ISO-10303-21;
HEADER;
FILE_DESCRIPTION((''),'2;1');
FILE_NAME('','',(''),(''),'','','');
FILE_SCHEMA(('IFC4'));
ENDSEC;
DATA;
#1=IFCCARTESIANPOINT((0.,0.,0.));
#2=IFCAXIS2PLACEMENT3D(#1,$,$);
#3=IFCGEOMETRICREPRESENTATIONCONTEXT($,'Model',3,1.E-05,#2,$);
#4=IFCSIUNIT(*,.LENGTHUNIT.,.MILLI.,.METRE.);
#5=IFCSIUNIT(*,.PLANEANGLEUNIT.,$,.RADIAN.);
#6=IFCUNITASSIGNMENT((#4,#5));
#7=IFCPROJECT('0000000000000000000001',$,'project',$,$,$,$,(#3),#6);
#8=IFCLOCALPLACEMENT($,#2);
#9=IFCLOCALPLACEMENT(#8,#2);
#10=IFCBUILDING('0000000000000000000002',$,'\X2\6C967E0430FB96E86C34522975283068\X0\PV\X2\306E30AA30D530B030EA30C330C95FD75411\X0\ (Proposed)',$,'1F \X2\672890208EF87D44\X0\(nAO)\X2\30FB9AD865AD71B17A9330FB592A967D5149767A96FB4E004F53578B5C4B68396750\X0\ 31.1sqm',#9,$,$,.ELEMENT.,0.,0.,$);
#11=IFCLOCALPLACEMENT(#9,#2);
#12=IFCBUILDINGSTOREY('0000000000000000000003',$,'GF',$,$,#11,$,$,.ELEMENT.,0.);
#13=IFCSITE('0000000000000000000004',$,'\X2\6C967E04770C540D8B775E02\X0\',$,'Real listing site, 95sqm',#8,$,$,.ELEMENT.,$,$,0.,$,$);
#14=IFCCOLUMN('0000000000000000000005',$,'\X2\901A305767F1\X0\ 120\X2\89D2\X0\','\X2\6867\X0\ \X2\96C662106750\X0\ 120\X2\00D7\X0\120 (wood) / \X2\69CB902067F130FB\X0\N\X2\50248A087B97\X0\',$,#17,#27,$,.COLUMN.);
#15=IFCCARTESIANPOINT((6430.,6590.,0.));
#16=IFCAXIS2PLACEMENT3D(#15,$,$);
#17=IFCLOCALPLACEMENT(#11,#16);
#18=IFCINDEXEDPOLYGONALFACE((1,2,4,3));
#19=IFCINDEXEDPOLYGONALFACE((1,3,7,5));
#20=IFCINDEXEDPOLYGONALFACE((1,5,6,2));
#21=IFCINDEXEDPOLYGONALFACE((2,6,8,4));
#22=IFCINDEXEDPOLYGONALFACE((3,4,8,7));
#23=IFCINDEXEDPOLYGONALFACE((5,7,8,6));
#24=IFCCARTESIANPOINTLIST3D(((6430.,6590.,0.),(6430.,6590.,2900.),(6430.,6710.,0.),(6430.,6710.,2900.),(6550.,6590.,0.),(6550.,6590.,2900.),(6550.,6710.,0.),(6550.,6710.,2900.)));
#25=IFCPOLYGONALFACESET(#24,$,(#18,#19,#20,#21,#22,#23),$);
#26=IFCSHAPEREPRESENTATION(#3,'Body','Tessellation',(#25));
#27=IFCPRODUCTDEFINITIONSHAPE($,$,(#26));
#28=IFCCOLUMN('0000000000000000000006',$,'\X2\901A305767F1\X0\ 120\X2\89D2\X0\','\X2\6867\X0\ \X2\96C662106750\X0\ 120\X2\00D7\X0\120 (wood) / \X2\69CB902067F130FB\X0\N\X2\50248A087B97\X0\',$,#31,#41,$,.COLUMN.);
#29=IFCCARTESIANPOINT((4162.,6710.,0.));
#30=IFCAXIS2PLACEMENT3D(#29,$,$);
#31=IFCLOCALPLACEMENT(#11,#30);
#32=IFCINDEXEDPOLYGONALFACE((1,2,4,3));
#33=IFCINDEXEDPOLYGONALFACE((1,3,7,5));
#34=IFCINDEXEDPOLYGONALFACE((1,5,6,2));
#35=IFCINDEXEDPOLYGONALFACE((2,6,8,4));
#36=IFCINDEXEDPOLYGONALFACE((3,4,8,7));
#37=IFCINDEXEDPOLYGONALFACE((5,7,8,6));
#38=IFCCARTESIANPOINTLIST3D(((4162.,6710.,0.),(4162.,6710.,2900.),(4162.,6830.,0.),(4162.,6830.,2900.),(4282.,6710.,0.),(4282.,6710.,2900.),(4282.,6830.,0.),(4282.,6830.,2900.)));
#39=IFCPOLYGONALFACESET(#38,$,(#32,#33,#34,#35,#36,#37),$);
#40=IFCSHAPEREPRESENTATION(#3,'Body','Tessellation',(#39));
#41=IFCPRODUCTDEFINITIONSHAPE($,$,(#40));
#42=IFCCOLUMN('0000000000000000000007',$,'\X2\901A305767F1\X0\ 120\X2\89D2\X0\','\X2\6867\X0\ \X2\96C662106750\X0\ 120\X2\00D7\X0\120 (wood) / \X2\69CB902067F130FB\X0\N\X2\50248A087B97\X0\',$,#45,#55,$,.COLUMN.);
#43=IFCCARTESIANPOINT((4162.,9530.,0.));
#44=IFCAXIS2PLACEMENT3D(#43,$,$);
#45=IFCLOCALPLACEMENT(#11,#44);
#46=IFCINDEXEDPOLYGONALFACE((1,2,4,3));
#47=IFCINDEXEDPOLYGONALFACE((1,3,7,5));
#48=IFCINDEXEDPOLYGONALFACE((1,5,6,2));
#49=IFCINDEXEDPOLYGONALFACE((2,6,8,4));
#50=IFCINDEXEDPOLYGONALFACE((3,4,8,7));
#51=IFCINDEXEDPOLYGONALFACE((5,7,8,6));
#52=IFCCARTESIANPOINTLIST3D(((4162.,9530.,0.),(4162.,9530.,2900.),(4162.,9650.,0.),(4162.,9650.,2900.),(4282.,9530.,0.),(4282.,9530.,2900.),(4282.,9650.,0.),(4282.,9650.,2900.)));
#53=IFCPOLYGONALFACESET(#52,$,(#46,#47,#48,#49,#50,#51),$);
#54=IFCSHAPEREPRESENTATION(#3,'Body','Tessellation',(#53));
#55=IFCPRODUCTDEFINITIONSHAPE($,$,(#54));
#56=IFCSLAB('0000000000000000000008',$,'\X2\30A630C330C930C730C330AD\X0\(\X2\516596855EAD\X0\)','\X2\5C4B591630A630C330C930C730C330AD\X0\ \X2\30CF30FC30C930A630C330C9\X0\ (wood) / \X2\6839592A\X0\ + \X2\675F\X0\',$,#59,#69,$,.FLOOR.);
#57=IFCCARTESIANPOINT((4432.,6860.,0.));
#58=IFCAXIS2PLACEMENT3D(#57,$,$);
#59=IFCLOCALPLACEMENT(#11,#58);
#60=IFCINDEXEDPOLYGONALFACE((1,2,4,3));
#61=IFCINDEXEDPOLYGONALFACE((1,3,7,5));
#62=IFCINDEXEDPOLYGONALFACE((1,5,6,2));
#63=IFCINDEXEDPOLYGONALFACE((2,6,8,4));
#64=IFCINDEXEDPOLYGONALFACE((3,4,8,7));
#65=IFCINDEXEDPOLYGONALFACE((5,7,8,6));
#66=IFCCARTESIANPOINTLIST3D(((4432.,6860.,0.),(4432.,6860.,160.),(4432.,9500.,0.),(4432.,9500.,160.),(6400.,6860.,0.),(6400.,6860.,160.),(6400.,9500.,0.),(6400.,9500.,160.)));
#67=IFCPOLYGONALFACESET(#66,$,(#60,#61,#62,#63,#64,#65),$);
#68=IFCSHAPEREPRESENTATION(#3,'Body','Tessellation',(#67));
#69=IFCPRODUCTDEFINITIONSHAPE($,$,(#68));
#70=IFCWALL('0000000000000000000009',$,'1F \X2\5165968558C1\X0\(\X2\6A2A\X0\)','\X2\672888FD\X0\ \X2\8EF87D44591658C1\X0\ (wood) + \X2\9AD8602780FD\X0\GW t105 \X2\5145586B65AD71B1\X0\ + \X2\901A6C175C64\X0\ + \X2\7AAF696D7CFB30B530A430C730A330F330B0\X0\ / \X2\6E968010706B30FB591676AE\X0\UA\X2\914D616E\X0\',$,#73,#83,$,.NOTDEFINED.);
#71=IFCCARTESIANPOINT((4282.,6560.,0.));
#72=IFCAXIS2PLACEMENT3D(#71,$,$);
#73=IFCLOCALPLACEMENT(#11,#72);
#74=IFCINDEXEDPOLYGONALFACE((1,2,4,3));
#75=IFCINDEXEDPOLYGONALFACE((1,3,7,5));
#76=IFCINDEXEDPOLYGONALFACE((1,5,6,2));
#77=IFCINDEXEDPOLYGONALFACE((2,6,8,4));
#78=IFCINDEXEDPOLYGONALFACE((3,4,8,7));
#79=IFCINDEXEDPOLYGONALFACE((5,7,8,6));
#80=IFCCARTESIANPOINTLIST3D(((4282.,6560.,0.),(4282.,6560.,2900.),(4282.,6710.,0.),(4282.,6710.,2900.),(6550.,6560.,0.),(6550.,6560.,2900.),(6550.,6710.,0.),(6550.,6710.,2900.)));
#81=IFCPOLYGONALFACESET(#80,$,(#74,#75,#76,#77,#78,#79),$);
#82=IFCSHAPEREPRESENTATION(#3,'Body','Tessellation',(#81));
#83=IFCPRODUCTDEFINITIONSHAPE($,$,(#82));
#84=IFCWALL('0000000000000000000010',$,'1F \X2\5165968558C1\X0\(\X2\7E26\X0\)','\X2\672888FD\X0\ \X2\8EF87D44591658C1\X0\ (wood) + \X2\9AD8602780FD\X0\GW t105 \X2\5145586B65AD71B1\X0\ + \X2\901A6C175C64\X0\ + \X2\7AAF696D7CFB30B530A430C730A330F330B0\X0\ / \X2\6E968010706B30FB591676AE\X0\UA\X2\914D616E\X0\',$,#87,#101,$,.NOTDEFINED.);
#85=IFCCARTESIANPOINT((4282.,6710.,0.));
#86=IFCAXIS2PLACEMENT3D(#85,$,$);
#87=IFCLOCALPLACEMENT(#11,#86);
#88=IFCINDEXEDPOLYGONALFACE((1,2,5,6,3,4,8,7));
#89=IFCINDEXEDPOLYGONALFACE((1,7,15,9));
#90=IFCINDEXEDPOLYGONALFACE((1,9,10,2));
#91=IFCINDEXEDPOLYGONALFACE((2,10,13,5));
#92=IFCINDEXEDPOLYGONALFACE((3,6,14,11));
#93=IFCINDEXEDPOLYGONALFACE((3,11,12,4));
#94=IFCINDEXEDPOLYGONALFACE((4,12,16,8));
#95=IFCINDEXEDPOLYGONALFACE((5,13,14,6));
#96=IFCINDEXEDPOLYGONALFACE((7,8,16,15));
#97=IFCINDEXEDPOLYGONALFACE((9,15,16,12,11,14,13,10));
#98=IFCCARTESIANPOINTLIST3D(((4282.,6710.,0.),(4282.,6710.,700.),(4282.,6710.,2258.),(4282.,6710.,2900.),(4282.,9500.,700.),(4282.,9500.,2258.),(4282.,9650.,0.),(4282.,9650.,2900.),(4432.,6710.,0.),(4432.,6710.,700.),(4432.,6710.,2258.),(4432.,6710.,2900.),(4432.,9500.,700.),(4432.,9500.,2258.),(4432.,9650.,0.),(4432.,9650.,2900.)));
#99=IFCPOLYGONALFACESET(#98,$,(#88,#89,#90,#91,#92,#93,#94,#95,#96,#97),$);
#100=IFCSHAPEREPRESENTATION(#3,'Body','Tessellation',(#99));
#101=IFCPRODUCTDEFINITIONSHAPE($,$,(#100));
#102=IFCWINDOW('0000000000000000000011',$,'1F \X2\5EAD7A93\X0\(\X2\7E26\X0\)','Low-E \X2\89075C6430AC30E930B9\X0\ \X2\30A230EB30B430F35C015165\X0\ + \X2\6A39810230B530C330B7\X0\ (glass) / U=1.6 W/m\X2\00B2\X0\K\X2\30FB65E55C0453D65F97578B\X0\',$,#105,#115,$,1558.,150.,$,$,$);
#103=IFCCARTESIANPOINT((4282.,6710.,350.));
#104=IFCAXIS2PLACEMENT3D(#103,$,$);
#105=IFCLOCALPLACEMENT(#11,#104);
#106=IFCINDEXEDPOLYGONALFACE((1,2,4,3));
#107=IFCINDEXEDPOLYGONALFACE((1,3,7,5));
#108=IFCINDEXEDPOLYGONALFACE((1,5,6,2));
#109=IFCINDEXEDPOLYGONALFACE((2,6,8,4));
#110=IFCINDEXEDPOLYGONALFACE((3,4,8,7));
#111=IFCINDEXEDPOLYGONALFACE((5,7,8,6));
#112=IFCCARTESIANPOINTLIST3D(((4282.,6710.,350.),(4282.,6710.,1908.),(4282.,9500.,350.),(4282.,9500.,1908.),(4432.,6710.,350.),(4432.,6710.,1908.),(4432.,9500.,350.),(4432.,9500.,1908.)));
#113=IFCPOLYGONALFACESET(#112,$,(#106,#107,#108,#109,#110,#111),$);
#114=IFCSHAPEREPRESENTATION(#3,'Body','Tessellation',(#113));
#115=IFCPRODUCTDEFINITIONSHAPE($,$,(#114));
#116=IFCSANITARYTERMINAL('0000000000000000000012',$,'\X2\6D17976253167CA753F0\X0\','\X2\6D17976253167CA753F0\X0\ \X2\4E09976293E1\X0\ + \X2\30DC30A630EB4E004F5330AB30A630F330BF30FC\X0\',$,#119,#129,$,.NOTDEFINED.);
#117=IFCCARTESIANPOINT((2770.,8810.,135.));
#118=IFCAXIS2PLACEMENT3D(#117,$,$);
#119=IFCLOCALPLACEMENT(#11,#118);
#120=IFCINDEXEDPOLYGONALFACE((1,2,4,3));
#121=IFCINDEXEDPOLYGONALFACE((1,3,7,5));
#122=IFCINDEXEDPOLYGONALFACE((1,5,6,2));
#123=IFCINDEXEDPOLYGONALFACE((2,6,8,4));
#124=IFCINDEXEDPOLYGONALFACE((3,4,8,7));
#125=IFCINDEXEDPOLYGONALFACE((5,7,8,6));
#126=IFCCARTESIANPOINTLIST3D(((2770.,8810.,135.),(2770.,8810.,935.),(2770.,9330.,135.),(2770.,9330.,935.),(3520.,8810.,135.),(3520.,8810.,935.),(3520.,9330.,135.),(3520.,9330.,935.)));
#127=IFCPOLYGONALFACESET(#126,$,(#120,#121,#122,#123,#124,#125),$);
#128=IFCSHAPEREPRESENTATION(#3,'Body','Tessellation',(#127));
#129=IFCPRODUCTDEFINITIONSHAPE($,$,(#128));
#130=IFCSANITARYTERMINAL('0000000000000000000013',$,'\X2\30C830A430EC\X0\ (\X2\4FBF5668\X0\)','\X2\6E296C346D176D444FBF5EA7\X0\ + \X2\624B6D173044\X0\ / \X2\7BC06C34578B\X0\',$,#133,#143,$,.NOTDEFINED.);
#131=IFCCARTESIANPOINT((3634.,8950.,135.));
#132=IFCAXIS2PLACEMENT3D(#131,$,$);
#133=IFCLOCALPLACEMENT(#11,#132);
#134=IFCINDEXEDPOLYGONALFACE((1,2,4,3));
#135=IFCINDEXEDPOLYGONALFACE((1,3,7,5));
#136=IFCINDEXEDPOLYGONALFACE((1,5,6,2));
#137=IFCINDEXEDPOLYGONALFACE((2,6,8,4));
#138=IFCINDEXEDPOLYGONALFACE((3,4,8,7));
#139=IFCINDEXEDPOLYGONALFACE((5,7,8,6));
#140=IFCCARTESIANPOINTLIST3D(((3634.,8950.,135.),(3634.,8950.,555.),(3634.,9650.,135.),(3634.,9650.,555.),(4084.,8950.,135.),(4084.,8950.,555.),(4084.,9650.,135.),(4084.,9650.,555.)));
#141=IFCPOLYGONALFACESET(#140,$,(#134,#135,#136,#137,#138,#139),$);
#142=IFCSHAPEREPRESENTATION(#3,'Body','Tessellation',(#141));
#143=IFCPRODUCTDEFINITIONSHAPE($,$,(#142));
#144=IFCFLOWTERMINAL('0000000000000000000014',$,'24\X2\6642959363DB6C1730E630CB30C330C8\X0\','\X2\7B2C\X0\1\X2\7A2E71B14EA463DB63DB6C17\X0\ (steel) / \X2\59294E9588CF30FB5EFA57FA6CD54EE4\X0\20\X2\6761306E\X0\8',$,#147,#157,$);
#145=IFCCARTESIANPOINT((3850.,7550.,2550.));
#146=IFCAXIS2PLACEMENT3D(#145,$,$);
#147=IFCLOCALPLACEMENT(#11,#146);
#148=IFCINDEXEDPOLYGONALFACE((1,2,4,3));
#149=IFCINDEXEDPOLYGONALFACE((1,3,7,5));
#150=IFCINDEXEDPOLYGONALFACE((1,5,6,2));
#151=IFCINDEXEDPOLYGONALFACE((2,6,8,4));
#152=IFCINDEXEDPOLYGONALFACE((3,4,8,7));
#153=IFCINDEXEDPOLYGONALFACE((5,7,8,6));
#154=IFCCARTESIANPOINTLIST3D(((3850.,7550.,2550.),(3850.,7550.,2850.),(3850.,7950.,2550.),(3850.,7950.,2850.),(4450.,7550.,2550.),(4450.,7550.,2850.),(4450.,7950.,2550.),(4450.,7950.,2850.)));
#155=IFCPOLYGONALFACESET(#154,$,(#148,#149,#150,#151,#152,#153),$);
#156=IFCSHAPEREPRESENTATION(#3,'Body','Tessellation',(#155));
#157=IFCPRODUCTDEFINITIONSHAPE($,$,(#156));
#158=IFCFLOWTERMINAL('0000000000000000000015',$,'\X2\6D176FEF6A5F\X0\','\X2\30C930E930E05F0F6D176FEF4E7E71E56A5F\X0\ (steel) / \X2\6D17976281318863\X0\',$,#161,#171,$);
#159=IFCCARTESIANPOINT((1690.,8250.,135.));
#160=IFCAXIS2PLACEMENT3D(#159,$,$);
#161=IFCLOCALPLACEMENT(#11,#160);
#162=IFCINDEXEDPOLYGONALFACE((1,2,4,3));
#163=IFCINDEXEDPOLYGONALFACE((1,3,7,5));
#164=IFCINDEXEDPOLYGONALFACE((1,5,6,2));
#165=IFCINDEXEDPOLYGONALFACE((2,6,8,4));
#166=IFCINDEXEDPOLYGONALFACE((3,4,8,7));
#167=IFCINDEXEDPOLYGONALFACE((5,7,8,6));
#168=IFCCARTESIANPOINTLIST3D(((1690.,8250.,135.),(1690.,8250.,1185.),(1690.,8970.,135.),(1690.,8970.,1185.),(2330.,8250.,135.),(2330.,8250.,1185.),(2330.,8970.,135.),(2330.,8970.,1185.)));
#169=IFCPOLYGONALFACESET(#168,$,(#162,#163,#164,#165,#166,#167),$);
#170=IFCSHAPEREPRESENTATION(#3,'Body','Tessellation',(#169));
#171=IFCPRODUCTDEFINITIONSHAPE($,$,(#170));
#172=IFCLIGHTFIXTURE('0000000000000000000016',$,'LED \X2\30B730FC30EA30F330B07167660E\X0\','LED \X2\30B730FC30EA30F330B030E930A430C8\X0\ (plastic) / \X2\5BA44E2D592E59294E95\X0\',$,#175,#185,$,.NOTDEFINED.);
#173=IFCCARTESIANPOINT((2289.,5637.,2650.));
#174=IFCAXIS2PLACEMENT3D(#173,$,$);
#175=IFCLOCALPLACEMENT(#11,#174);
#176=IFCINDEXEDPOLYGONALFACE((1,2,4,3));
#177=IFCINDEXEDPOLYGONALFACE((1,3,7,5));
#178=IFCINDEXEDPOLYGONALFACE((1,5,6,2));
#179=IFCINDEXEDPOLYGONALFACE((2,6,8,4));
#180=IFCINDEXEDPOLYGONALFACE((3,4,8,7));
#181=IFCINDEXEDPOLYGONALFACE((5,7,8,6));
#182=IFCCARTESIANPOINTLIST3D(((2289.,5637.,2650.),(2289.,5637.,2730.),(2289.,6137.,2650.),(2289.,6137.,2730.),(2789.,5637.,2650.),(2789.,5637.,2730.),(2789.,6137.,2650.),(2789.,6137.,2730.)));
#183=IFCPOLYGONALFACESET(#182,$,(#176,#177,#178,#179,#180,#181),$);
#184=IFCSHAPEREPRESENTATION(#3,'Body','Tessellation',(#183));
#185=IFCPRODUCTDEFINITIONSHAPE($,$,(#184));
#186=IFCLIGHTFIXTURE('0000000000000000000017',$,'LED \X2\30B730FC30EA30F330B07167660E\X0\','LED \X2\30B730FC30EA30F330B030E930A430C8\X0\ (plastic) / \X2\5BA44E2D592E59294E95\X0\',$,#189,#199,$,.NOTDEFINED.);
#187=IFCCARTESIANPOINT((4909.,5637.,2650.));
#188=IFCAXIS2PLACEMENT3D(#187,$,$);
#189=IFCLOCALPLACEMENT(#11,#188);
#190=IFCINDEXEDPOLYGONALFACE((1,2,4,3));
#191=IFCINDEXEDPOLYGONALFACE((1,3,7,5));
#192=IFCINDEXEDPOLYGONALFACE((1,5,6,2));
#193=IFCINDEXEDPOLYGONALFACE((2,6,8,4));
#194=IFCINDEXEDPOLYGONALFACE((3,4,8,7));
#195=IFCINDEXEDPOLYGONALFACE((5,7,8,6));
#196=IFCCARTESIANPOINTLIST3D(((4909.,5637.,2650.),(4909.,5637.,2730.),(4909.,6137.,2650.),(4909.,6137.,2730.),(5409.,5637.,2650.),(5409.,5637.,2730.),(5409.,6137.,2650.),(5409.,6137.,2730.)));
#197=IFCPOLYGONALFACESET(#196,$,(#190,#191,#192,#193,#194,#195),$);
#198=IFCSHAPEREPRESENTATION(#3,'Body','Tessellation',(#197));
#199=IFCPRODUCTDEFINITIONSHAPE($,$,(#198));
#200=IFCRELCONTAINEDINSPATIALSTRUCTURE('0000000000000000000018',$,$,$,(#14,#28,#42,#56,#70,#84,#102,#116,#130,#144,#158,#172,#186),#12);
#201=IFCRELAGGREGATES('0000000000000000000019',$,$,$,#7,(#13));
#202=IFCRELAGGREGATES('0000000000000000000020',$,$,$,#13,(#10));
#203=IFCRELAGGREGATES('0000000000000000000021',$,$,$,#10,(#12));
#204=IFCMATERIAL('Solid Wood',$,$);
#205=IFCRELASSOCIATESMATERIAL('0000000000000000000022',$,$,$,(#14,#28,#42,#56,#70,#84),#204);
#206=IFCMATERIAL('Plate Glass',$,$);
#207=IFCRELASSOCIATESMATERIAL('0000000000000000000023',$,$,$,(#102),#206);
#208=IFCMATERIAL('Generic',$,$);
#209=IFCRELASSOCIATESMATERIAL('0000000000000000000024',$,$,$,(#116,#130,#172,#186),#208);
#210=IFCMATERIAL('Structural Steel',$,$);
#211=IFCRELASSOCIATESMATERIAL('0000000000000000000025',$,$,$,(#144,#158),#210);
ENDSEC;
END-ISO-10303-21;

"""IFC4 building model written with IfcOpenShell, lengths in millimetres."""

from ifc_helpers import new_model, si_unit, frame, frame_2d, origin, place, context, project, spatial, rectangle, extrude, material, element, fill, save


model = new_model("IFC4")

# Units and contexts
model_context = context("Model", 3, precision=1e-05, world=origin())
ifc_project = project(units=[si_unit("LENGTHUNIT", "METRE", prefix="MILLI"), si_unit("PLANEANGLEUNIT", "RADIAN")], contexts=[model_context])

# Site, building, storey
site_placement = place(None, origin())
site = spatial("IfcSite", under=ifc_project, at=site_placement, Name="沖縄県名護市", ObjectType="Real listing site, 95sqm", CompositionType="ELEMENT", RefElevation=0.0)
building_placement = place(site_placement, origin())
building = spatial("IfcBuilding", under=site, at=building_placement, Name="沖縄・雨水利用とPVのオフグリッド志向 (Proposed)", ObjectType="1F 木造軸組(nAO)・高断熱窓・太陽光発電一体型屋根材 31.1sqm", CompositionType="ELEMENT", ElevationOfRefHeight=0.0, ElevationOfTerrain=0.0)
storey_placement = place(building_placement, origin())
storey = spatial("IfcBuildingStorey", under=building, at=storey_placement, Name="GF", CompositionType="ELEMENT", Elevation=0.0)

# Columns
ifc_material_1 = material(Name="Solid Wood")
column_1_placement = place(storey_placement, frame((6430.0, 6590.0, 0.0)))
element("IfcColumn", 1, at=column_1_placement, inside=storey, material=ifc_material_1, Name="通し柱 120角", Description="桧 集成材 120×120 (wood) / 構造柱・N値計算", PredefinedType="COLUMN", context=model_context, shape_type="SweptSolid", body=[
    extrude(rectangle(XDim=120.0, YDim=120.0, at=frame_2d((60.0, 60.0))), frame((6430.0, 6590.0, 0.0)), (0.0, 0.0, 1.0), 2900.0),
])
column_2_placement = place(storey_placement, frame((4162.0, 6710.0, 0.0)))
element("IfcColumn", 2, at=column_2_placement, inside=storey, material=ifc_material_1, Name="通し柱 120角", Description="桧 集成材 120×120 (wood) / 構造柱・N値計算", PredefinedType="COLUMN", context=model_context, shape_type="SweptSolid", body=[
    extrude(rectangle(XDim=120.0, YDim=120.0, at=frame_2d((60.0, 60.0))), frame((4162.0, 6710.0, 0.0)), (0.0, 0.0, 1.0), 2900.0),
])
column_3_placement = place(storey_placement, frame((4162.0, 9530.0, 0.0)))
element("IfcColumn", 3, at=column_3_placement, inside=storey, material=ifc_material_1, Name="通し柱 120角", Description="桧 集成材 120×120 (wood) / 構造柱・N値計算", PredefinedType="COLUMN", context=model_context, shape_type="SweptSolid", body=[
    extrude(rectangle(XDim=120.0, YDim=120.0, at=frame_2d((60.0, 60.0))), frame((4162.0, 9530.0, 0.0)), (0.0, 0.0, 1.0), 2900.0),
])

# Slab
slab_placement = place(storey_placement, frame((4432.0, 6860.0, 0.0)))
element("IfcSlab", 4, at=slab_placement, inside=storey, material=ifc_material_1, Name="ウッドデッキ(入隅庭)", Description="屋外ウッドデッキ ハードウッド (wood) / 根太 + 束", PredefinedType="FLOOR", context=model_context, shape_type="SweptSolid", body=[
    extrude(rectangle(XDim=1968.0, YDim=2640.0, at=frame_2d((984.0, 1320.0))), frame((4432.0, 6860.0, 0.0)), (0.0, 0.0, 1.0), 160.0),
])

# Wall
wall_1_placement = place(storey_placement, frame((4282.0, 6560.0, 0.0)))
element("IfcWall", 5, at=wall_1_placement, inside=storey, material=ifc_material_1, Name="1F 入隅壁(横)", Description="木製 軸組外壁 (wood) + 高性能GW t105 充填断熱 + 通気層 + 窯業系サイディング / 準耐火・外皮UA配慮", PredefinedType="NOTDEFINED", context=model_context, shape_type="SweptSolid", body=[
    extrude(rectangle(XDim=2268.0, YDim=150.0, at=frame_2d((1134.0, 75.0))), frame((4282.0, 6560.0, 0.0)), (0.0, 0.0, 1.0), 2900.0),
])

# Wall, opening, window
wall_2_placement = place(storey_placement, frame((4282.0, 6710.0, 0.0)))
wall_2 = element("IfcWall", 6, at=wall_2_placement, inside=storey, material=ifc_material_1, Name="1F 入隅壁(縦)", Description="木製 軸組外壁 (wood) + 高性能GW t105 充填断熱 + 通気層 + 窯業系サイディング / 準耐火・外皮UA配慮", PredefinedType="NOTDEFINED", context=model_context, shape_type="SweptSolid", body=[
    extrude(rectangle(XDim=150.0, YDim=2940.0, at=frame_2d((75.0, 1470.0))), frame((4282.0, 6710.0, 0.0)), (0.0, 0.0, 1.0), 2900.0),
])
opening_placement = place(storey_placement, frame((4282.0, 6710.0, 350.0)))
opening = element("IfcOpeningElement", 7, at=opening_placement, cuts=wall_2, PredefinedType="NOTDEFINED", context=model_context, shape_type="SweptSolid", body=[
    extrude(rectangle(XDim=150.0, YDim=2790.0, at=frame_2d((75.0, 1395.0))), frame((4282.0, 6710.0, 350.0)), (0.0, 0.0, 1.0), 1558.0),
])
ifc_material_2 = material(Name="Plate Glass")
window_placement = place(storey_placement, frame((4282.0, 6710.0, 350.0)))
window = element("IfcWindow", 8, at=window_placement, inside=storey, material=ifc_material_2, Name="1F 庭窓(縦)", Description="Low-E 複層ガラス アルゴン封入 + 樹脂サッシ (glass) / U=1.6 W/m²K・日射取得型", OverallHeight=1558.0, OverallWidth=150.0, context=model_context, shape_type="SweptSolid", body=[
    extrude(rectangle(XDim=150.0, YDim=2790.0, at=frame_2d((75.0, 1395.0))), frame((4282.0, 6710.0, 350.0)), (0.0, 0.0, 1.0), 1558.0),
])
fill(opening, window)

# Sanitary terminals
ifc_material_3 = material(Name="Generic")
sanitary_terminal_1_placement = place(storey_placement, frame((2770.0, 8810.0, 135.0)))
element("IfcSanitaryTerminal", 9, at=sanitary_terminal_1_placement, inside=storey, material=ifc_material_3, Name="洗面化粧台", Description="洗面化粧台 三面鏡 + ボウル一体カウンター", PredefinedType="NOTDEFINED", context=model_context, shape_type="SweptSolid", body=[
    extrude(rectangle(XDim=750.0, YDim=520.0, at=frame_2d((375.0, 260.0))), frame((2770.0, 8810.0, 135.0)), (0.0, 0.0, 1.0), 800.0),
])
sanitary_terminal_2_placement = place(storey_placement, frame((3634.0, 8950.0, 135.0)))
element("IfcSanitaryTerminal", 10, at=sanitary_terminal_2_placement, inside=storey, material=ifc_material_3, Name="トイレ (便器)", Description="温水洗浄便座 + 手洗い / 節水型", PredefinedType="NOTDEFINED", context=model_context, shape_type="SweptSolid", body=[
    extrude(rectangle(XDim=450.0, YDim=700.0, at=frame_2d((225.0, 350.0))), frame((3634.0, 8950.0, 135.0)), (0.0, 0.0, 1.0), 420.0),
])

# Flow terminals
ifc_material_4 = material(Name="Structural Steel")
flow_terminal_1_placement = place(storey_placement, frame((3850.0, 7550.0, 2550.0)))
element("IfcFlowTerminal", 11, at=flow_terminal_1_placement, inside=storey, material=ifc_material_4, Name="24時間換気ユニット", Description="第1種熱交換換気 (steel) / 天井裏・建基法令20条の8", context=model_context, shape_type="SweptSolid", body=[
    extrude(rectangle(XDim=600.0, YDim=400.0, at=frame_2d((300.0, 200.0))), frame((3850.0, 7550.0, 2550.0)), (0.0, 0.0, 1.0), 300.0),
])
flow_terminal_2_placement = place(storey_placement, frame((1690.0, 8250.0, 135.0)))
element("IfcFlowTerminal", 12, at=flow_terminal_2_placement, inside=storey, material=ifc_material_4, Name="洗濯機", Description="ドラム式洗濯乾燥機 (steel) / 洗面脱衣", context=model_context, shape_type="SweptSolid", body=[
    extrude(rectangle(XDim=640.0, YDim=720.0, at=frame_2d((320.0, 360.0))), frame((1690.0, 8250.0, 135.0)), (0.0, 0.0, 1.0), 1050.0),
])

# Light fixtures
light_fixture_1_placement = place(storey_placement, frame((2289.0, 5637.0, 2650.0)))
element("IfcLightFixture", 13, at=light_fixture_1_placement, inside=storey, material=ifc_material_3, Name="LED シーリング照明", Description="LED シーリングライト (plastic) / 室中央天井", PredefinedType="NOTDEFINED", context=model_context, shape_type="SweptSolid", body=[
    extrude(rectangle(XDim=500.0, YDim=500.0, at=frame_2d((250.0, 250.0))), frame((2289.0, 5637.0, 2650.0)), (0.0, 0.0, 1.0), 80.0),
])
light_fixture_2_placement = place(storey_placement, frame((4909.0, 5637.0, 2650.0)))
element("IfcLightFixture", 14, at=light_fixture_2_placement, inside=storey, material=ifc_material_3, Name="LED シーリング照明", Description="LED シーリングライト (plastic) / 室中央天井", PredefinedType="NOTDEFINED", context=model_context, shape_type="SweptSolid", body=[
    extrude(rectangle(XDim=500.0, YDim=500.0, at=frame_2d((250.0, 250.0))), frame((4909.0, 5637.0, 2650.0)), (0.0, 0.0, 1.0), 80.0),
])

save(model, "model.ifc")
